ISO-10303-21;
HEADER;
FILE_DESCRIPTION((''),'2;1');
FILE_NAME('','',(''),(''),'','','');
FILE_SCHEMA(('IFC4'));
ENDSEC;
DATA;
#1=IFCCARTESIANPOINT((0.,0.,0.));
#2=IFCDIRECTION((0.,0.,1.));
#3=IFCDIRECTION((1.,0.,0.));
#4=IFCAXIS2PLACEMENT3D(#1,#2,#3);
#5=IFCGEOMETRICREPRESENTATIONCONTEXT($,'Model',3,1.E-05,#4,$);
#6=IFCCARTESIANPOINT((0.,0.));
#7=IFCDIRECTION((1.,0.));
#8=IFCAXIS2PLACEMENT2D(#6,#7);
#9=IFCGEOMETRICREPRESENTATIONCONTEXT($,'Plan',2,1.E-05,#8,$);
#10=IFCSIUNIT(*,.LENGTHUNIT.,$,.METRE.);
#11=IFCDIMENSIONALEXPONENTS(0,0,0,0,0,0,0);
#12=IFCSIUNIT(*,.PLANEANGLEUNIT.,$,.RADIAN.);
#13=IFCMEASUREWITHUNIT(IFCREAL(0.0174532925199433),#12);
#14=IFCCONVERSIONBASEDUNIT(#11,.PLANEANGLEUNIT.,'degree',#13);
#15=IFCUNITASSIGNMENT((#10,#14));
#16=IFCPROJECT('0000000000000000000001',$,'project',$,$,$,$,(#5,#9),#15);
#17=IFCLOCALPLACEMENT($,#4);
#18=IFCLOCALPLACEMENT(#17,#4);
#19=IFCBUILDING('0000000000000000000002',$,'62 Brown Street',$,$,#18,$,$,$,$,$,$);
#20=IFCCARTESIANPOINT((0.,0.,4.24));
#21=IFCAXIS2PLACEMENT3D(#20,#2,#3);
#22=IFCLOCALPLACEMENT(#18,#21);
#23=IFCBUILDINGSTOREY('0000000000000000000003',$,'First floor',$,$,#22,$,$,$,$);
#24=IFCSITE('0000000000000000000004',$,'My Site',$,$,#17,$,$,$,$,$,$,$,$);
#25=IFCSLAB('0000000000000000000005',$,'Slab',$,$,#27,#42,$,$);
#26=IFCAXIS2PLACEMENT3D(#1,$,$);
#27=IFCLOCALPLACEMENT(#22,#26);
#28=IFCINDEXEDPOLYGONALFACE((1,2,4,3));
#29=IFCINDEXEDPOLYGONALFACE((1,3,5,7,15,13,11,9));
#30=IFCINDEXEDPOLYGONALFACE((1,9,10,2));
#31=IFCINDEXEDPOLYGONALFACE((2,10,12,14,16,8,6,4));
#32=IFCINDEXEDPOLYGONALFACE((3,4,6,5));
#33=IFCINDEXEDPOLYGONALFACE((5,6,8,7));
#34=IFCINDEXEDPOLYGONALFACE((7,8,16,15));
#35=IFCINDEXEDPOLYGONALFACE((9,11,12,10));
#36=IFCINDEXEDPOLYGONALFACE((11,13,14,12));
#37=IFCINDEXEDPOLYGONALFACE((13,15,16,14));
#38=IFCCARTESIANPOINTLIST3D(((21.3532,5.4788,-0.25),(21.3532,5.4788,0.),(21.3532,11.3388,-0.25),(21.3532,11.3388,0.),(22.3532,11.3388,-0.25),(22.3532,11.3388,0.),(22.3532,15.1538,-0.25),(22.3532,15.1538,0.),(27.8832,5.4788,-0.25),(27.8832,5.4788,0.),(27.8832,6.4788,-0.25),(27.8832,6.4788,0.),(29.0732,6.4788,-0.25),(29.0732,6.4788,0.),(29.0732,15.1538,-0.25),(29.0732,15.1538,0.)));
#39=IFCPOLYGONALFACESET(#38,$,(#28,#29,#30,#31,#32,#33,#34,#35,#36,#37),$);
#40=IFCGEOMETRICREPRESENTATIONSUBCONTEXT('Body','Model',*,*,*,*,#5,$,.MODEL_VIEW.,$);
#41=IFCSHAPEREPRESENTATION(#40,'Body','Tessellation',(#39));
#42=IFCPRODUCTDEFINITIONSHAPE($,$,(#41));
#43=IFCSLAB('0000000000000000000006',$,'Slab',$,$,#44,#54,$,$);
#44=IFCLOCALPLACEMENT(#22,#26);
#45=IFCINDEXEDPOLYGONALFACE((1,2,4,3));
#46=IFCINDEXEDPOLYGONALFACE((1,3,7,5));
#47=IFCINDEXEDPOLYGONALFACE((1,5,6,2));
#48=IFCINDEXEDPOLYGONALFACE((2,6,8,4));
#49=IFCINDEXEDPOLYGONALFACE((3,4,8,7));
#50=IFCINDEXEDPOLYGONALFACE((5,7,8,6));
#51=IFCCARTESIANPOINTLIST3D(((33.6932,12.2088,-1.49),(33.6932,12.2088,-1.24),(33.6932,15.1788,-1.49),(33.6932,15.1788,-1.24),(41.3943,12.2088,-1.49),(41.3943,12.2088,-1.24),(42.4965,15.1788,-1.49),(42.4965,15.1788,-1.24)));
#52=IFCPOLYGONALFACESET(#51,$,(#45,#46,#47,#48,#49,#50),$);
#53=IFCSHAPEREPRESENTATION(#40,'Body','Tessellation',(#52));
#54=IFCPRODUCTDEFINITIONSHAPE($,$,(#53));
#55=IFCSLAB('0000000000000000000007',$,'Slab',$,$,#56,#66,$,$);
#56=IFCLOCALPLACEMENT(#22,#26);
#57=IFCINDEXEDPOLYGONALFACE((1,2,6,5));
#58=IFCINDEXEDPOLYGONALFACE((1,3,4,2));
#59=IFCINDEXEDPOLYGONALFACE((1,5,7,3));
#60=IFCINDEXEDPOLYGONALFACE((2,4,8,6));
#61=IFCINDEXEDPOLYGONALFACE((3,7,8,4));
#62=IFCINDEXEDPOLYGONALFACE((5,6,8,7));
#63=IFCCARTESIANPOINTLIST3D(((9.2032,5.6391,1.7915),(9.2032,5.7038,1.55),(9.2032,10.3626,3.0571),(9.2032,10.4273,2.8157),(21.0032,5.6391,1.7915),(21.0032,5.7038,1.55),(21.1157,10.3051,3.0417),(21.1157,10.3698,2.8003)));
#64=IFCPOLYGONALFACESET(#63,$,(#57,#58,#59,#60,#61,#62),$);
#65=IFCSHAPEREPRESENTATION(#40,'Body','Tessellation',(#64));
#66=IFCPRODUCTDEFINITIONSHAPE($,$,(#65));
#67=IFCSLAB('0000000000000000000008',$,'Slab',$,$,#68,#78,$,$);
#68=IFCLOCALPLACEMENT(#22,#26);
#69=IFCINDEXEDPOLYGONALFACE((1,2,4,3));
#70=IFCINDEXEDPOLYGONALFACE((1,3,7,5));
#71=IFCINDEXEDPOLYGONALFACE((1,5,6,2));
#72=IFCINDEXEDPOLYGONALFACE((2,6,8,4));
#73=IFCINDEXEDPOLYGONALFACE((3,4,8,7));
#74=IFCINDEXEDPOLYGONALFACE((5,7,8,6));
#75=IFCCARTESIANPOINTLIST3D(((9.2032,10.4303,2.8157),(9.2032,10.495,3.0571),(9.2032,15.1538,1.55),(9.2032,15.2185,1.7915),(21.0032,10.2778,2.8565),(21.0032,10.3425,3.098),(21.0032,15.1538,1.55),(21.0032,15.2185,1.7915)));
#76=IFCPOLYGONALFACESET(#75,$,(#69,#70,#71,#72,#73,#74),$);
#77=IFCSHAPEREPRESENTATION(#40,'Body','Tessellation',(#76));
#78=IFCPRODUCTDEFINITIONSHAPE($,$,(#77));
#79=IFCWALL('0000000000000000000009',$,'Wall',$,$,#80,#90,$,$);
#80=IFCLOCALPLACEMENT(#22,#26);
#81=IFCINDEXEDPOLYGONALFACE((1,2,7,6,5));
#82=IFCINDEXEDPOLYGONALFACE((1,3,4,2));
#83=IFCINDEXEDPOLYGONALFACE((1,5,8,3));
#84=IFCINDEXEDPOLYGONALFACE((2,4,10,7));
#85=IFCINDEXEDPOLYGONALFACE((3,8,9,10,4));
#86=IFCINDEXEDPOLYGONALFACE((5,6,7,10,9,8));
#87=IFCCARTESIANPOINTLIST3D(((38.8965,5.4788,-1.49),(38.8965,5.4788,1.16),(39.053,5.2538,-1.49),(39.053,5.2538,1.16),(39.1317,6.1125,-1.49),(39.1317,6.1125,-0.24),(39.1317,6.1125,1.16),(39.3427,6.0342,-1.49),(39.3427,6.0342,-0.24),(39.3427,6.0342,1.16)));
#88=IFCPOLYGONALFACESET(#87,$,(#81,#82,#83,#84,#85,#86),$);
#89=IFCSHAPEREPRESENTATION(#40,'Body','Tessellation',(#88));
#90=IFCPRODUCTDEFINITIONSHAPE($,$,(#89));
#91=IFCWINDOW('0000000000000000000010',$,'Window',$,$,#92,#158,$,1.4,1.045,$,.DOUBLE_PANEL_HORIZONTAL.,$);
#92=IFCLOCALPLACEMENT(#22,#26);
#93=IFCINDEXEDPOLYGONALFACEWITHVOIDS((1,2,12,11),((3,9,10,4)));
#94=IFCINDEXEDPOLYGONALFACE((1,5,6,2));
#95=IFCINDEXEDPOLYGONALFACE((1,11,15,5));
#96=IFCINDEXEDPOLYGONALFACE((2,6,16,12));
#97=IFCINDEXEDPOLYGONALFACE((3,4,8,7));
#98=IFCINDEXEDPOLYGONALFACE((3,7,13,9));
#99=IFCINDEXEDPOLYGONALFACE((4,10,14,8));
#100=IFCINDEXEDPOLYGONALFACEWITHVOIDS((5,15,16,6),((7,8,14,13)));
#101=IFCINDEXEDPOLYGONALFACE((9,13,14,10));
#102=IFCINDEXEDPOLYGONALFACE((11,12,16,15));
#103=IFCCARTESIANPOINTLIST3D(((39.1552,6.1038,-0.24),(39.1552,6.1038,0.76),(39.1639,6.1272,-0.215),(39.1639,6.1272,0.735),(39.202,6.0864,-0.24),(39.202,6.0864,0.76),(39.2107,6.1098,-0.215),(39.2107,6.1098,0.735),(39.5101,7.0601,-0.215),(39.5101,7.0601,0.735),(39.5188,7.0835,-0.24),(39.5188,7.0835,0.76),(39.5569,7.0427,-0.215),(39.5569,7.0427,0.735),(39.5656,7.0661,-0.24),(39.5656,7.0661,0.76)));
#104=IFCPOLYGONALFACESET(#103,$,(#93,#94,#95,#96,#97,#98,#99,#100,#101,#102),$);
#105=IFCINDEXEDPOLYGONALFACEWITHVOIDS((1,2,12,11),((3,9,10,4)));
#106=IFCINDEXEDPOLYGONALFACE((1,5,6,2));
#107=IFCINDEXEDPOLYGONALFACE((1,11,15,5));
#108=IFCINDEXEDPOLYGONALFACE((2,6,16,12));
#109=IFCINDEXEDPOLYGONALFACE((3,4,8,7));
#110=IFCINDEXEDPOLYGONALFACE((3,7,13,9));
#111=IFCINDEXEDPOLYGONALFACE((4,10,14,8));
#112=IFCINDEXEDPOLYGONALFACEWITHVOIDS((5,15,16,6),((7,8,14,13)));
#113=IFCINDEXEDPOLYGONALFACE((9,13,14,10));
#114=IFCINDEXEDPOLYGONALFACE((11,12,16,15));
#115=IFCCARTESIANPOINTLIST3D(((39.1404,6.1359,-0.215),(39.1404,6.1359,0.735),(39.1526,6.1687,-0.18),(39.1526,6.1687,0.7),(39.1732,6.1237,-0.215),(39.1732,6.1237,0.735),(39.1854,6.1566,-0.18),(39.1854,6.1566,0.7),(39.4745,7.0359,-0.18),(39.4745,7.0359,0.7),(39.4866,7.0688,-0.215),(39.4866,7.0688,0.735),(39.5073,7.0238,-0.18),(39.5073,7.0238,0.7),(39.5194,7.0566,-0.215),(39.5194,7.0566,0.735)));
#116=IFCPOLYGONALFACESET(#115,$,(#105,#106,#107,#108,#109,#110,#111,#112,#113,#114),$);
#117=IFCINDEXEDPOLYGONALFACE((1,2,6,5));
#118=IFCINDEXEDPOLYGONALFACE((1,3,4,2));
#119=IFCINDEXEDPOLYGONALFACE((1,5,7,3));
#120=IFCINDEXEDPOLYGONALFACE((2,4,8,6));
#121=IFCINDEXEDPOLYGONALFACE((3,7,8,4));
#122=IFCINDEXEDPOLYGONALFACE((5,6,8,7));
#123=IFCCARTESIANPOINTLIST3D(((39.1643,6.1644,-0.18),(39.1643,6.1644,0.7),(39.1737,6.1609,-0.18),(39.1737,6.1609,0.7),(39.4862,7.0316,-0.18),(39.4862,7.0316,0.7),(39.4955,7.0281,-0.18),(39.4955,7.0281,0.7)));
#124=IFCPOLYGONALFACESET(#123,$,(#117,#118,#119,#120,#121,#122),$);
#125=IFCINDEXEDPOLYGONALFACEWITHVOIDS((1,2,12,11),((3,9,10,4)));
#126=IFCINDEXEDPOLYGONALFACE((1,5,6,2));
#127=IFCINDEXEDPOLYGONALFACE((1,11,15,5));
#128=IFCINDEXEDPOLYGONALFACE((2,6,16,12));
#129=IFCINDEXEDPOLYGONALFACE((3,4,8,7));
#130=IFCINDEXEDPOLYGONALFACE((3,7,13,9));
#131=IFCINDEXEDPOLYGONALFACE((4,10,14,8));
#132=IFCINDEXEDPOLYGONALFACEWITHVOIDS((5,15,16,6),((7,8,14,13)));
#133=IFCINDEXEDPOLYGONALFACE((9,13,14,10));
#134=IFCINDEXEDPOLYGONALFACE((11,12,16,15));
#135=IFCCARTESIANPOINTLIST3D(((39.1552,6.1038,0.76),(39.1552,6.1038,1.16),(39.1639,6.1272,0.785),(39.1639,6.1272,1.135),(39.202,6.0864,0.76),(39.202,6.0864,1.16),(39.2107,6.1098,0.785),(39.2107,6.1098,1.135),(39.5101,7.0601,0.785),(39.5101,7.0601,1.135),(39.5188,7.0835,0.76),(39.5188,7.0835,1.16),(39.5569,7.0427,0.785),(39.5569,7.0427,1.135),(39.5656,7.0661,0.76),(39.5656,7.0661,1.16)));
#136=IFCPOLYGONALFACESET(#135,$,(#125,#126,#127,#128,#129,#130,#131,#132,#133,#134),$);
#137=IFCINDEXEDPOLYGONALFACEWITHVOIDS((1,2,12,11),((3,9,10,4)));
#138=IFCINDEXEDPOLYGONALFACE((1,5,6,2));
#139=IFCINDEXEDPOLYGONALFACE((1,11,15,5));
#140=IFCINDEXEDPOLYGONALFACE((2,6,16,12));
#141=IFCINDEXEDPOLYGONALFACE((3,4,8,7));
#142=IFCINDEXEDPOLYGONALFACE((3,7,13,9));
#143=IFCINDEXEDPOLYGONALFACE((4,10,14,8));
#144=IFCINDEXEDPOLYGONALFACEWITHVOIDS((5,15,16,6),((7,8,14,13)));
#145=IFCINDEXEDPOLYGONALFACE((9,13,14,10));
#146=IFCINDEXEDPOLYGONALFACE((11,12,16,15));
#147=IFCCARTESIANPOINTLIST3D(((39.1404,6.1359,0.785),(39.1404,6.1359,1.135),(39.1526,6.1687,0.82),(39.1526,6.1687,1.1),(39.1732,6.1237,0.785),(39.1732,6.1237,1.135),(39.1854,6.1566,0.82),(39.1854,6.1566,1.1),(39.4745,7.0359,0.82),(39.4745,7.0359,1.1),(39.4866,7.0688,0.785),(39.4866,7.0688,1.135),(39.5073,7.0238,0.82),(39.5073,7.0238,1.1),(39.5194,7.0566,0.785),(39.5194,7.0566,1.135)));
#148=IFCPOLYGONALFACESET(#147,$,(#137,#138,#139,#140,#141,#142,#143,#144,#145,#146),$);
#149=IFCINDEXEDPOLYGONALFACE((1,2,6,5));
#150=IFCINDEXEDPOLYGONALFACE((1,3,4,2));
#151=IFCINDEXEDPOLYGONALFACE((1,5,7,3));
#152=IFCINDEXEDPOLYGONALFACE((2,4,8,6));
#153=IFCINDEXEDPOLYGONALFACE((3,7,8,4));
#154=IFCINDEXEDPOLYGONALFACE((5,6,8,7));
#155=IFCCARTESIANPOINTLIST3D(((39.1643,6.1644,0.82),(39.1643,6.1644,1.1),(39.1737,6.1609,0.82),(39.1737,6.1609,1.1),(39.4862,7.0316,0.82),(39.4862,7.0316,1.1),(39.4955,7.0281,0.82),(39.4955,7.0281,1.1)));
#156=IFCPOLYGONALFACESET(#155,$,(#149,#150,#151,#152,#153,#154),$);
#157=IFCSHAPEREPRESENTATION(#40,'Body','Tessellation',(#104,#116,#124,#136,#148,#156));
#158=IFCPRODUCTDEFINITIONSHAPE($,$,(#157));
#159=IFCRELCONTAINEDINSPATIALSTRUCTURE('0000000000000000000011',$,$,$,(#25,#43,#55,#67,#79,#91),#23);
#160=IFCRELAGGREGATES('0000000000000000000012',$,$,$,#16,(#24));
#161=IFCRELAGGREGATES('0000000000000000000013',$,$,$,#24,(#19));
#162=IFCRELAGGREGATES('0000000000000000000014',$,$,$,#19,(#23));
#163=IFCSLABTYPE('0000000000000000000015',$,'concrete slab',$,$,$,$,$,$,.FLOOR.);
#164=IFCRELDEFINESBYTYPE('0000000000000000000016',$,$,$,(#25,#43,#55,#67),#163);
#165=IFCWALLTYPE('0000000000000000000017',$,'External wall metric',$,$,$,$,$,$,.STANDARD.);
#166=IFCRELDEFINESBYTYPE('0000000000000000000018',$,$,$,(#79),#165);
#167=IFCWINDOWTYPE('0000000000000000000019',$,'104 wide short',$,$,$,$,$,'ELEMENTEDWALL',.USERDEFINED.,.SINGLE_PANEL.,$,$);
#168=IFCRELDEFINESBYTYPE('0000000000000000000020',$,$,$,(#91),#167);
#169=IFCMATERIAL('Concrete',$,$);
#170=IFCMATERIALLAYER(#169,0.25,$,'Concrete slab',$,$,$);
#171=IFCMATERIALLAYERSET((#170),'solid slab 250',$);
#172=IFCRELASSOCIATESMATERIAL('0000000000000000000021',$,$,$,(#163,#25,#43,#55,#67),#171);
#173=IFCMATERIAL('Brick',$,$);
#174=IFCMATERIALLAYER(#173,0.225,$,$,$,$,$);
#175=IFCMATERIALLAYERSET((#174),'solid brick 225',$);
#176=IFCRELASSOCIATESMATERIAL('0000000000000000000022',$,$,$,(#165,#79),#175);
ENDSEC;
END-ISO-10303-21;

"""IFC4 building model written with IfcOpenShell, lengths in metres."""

from ifc_helpers import new_model, entity, si_unit, converted_unit, frame, origin_with_axes, origin_2d_with_axis, place, context, subcontext, project, spatial, line, indexed_curve, outline, extrude, clip, halfspace, shape, source, transform, mapped, material, layer, layer_set, layer_usage, type_object, type_shapes, element, fill, save


model = new_model("IFC4")

# Units and contexts
model_context = context("Model", 3, precision=1e-05, world=origin_with_axes())
plan_context = context("Plan", 2, precision=1e-05, world=origin_2d_with_axis())
body_context_1 = subcontext(model_context, "Body", "Model", "MODEL_VIEW")
body_context_2 = subcontext(plan_context, "Body", "Plan", "PLAN_VIEW")
ifc_project = project(units=[si_unit("LENGTHUNIT", "METRE"), converted_unit("PLANEANGLEUNIT", "degree", entity("IfcReal", 0.0174532925199433), si_unit("PLANEANGLEUNIT", "RADIAN"), dimensions=[0, 0, 0, 0, 0, 0, 0])], contexts=[model_context, plan_context])

# Site, building, storey
site_placement = place(None, origin_with_axes())
site = spatial("IfcSite", under=ifc_project, at=site_placement, Name="My Site")
building_placement = place(site_placement, origin_with_axes())
building = spatial("IfcBuilding", under=site, at=building_placement, Name="62 Brown Street")
storey_placement = place(building_placement, frame((0.0, 0.0, 4.24), z_axis=(0.0, 0.0, 1.0), x_axis=(1.0, 0.0, 0.0)))
storey = spatial("IfcBuildingStorey", under=building, at=storey_placement, Name="First floor")

# Slabs
ifc_material_1 = material(Name="Concrete")
ifc_layer_1 = layer(ifc_material_1, 0.25, Name="Concrete slab")
ifc_layer_set_1 = layer_set([ifc_layer_1], Name="solid slab 250")
ifc_layer_usage_1 = layer_usage(ifc_layer_set_1, "AXIS3", "POSITIVE", 0.0)
slab_type = type_object("IfcSlabType", Name="concrete slab", PredefinedType="FLOOR", material=ifc_layer_set_1)
slab_1_placement = place(storey_placement, frame((21.3532, 5.4788, -0.25), z_axis=(0.0, 0.0, 1.0), x_axis=(1.0, 0.0, 0.0)))
element("IfcSlab", 1, at=slab_1_placement, inside=storey, type_object=slab_type, material=ifc_layer_usage_1, Name="Slab", context=body_context_1, shape_type="SweptSolid", body=[
    extrude(outline(indexed_curve([(0.0, 0.0), (0.0, 5.86), (1.0, 5.86), (1.0, 9.675), (7.72, 9.675), (7.72, 1.0), (6.53, 1.0), (6.53, 0.0)], segments=[line(2, 1), line(1, 8), line(8, 7), line(7, 6), line(6, 5), line(5, 4), line(4, 3), line(3, 2)], self_intersect=False)), None, (0.0, 0.0, 1.0), 0.25),
])
ifc_layer_usage_2 = layer_usage(ifc_layer_set_1, "AXIS3", "POSITIVE", 0.0)
slab_2_placement = place(storey_placement, frame((33.6932, 12.2088, -1.49), z_axis=(0.0, 0.0, 1.0), x_axis=(1.0, 0.0, 0.0)))
element("IfcSlab", 2, at=slab_2_placement, inside=storey, type_object=slab_type, material=ifc_layer_usage_2, Name="Slab", context=body_context_1, shape_type="SweptSolid", body=[
    extrude(outline(indexed_curve([(8.8033, 2.97), (7.7011, 0.0), (0.0, 0.0), (0.0, 2.97)], segments=[line(4, 1), line(1, 2), line(2, 3), line(3, 4)], self_intersect=False)), None, (0.0, 0.0, 1.0), 0.25),
])
ifc_layer_usage_3 = layer_usage(ifc_layer_set_1, "AXIS3", "POSITIVE", 0.0)
slab_3_placement = place(storey_placement, frame((9.2032, 5.7038, 1.55), z_axis=(0.0, -0.258819, 0.965926), x_axis=(1.0, 0.0, 0.0)))
element("IfcSlab", 3, at=slab_3_placement, inside=storey, type_object=slab_type, material=ifc_layer_usage_3, Name="Slab", context=body_context_1, shape_type="SweptSolid", body=[
    extrude(outline(indexed_curve([(0.0, 0.0), (11.8, 0.0), (11.9125, 4.8306), (0.0, 4.8901)], segments=[line(4, 1), line(1, 2), line(2, 3), line(3, 4)], self_intersect=False)), None, (0.0, 0.0, 1.0), 0.25),
])
ifc_layer_usage_4 = layer_usage(ifc_layer_set_1, "AXIS3", "POSITIVE", 0.0)
slab_4_placement = place(storey_placement, frame((21.0032, 15.1538, 1.55), z_axis=(0.0, 0.258819, 0.965926), x_axis=(-1.0, 0.0, 0.0)))
element("IfcSlab", 4, at=slab_4_placement, inside=storey, type_object=slab_type, material=ifc_layer_usage_4, Name="Slab", context=body_context_1, shape_type="SweptSolid", body=[
    extrude(outline(indexed_curve([(0.0, 0.0), (11.8, 0.0), (11.8, 4.8901), (0.0, 5.048)], segments=[line(4, 1), line(1, 2), line(2, 3), line(3, 4)], self_intersect=False)), None, (0.0, 0.0, 1.0), 0.25),
])

# Shared definitions
ifc_material_2 = material(Name="Brick")
ifc_layer_2 = layer(ifc_material_2, 0.225)
ifc_layer_set_2 = layer_set([ifc_layer_2], Name="solid brick 225")
wall_type_1 = type_object("IfcWallType", Name="External wall metric", PredefinedType="STANDARD", material=ifc_layer_set_2)

# Wall, opening, window
ifc_layer_usage_5 = layer_usage(ifc_layer_set_2, "AXIS2", "POSITIVE", 0.0)
wall_1_placement = place(storey_placement, frame((39.024, 5.1755, -1.49), z_axis=(0.0, 0.0, 1.0), x_axis=(0.347944, 0.937515, 0.0)))
wall_1 = element("IfcWall", 5, at=wall_1_placement, inside=storey, type_object=wall_type_1, material=ifc_layer_usage_5, Name="Wall", context=body_context_1, shape_type="Clipping", body=[
    clip(extrude(outline(indexed_curve([(0.0, 0.0), (0.0, 0.225), (0.9159, 0.225), (0.9159, 0.0), (0.0, 0.0)], self_intersect=False)), origin_with_axes(), (0.0, 0.0, 1.0), 2.65), halfspace(frame((0.0835, 0.0, -2.75), z_axis=(-0.596249, 0.414702, 0.0), x_axis=(0.156491, 0.225, 0.0)), False)),
])
shared_shape_1 = source(origin_with_axes(), body_context_1, "Body", "SweptSolid", [
    extrude(outline(indexed_curve([(0.0, 0.0), (1.045, 0.0), (1.045, 1.4), (0.0, 1.4)], segments=[line(1, 2, 3, 4, 1)])), frame((0.0, -0.1, 0.0), z_axis=(0.0, -1.0, 0.0), x_axis=(1.0, 0.0, 0.0)), (0.0, 0.0, -1.0), 0.425),
])
opening_placement = place(wall_1_placement, frame((0.9159, 0.0, 1.25), z_axis=(0.0, 0.0, 1.0), x_axis=(1.0, 0.0, 0.0)))
opening = element("IfcOpeningElement", 6, at=opening_placement, cuts=wall_1, PredefinedType="OPENING", context=body_context_1, shape_type="MappedRepresentation", body=[
    mapped(shared_shape_1, transform((0.0, 0.0, 0.0), x_axis=(1.0, 0.0, 0.0), y_axis=(0.0, 1.0, 0.0), z_axis=(0.0, 0.0, 1.0), scale=1.0)),
])
window_type = type_object("IfcWindowType", Name="104 wide short", ElementType="ELEMENTEDWALL", PartitioningType="SINGLE_PANEL", PredefinedType="USERDEFINED")
shared_shape_2 = source(origin_with_axes(), body_context_1, "Body", "SweptSolid", [
    extrude(outline(indexed_curve([(0.0, 0.0), (1.045, 0.0), (1.045, 1.0), (0.0, 1.0)], segments=[line(1, 2, 3, 4, 1)]), holes=[indexed_curve([(0.025, 0.025), (1.02, 0.025), (1.02, 0.975), (0.025, 0.975)], segments=[line(1, 2, 3, 4, 1)])]), frame((0.0, 0.15, 0.0), z_axis=(0.0, -1.0, 0.0), x_axis=(1.0, 0.0, 0.0)), (0.0, 0.0, -1.0), 0.05),
    extrude(outline(indexed_curve([(0.0, 0.0), (0.995, 0.0), (0.995, 0.95), (0.0, 0.95)], segments=[line(1, 2, 3, 4, 1)]), holes=[indexed_curve([(0.035, 0.035), (0.96, 0.035), (0.96, 0.915), (0.035, 0.915)], segments=[line(1, 2, 3, 4, 1)])]), frame((0.025, 0.19, 0.025), z_axis=(0.0, -1.0, 0.0), x_axis=(1.0, 0.0, 0.0)), (0.0, 0.0, -1.0), 0.035),
    extrude(outline(indexed_curve([(0.035, 0.035), (0.96, 0.035), (0.96, 0.915), (0.035, 0.915)], segments=[line(1, 2, 3, 4, 1)])), frame((0.025, 0.2025, 0.025), z_axis=(0.0, -1.0, 0.0), x_axis=(1.0, 0.0, 0.0)), (0.0, 0.0, -1.0), 0.01),
    extrude(outline(indexed_curve([(0.0, 0.0), (1.045, 0.0), (1.045, 0.4), (0.0, 0.4)], segments=[line(1, 2, 3, 4, 1)]), holes=[indexed_curve([(0.025, 0.025), (1.02, 0.025), (1.02, 0.375), (0.025, 0.375)], segments=[line(1, 2, 3, 4, 1)])]), frame((0.0, 0.15, 1.0), z_axis=(0.0, -1.0, 0.0), x_axis=(1.0, 0.0, 0.0)), (0.0, 0.0, -1.0), 0.05),
    extrude(outline(indexed_curve([(0.0, 0.0), (0.995, 0.0), (0.995, 0.35), (0.0, 0.35)], segments=[line(1, 2, 3, 4, 1)]), holes=[indexed_curve([(0.035, 0.035), (0.96, 0.035), (0.96, 0.315), (0.035, 0.315)], segments=[line(1, 2, 3, 4, 1)])]), frame((0.025, 0.19, 1.025), z_axis=(0.0, -1.0, 0.0), x_axis=(1.0, 0.0, 0.0)), (0.0, 0.0, -1.0), 0.035),
    extrude(outline(indexed_curve([(0.035, 0.035), (0.96, 0.035), (0.96, 0.315), (0.035, 0.315)], segments=[line(1, 2, 3, 4, 1)])), frame((0.025, 0.2025, 1.025), z_axis=(0.0, -1.0, 0.0), x_axis=(1.0, 0.0, 0.0)), (0.0, 0.0, -1.0), 0.01),
])
shared_shape_3 = source(origin_with_axes(), body_context_2, "Body", "Curve2D", [
    entity("IfcIndexedPolyCurve", entity("IfcCartesianPointList2D", [[0.025, 0.15], [1.02, 0.15]])),
    entity("IfcIndexedPolyCurve", entity("IfcCartesianPointList2D", [[0.0, 0.2], [0.025, 0.2], [0.025, 0.15], [0.0, 0.15]]), [entity("IfcLineIndex", [1, 2, 3, 4, 1])]),
    entity("IfcIndexedPolyCurve", entity("IfcCartesianPointList2D", [[1.045, 0.2], [1.02, 0.2], [1.02, 0.15], [1.045, 0.15]]), [entity("IfcLineIndex", [1, 2, 3, 4, 1])]),
    entity("IfcIndexedPolyCurve", entity("IfcCartesianPointList2D", [[0.025, 0.19], [0.06, 0.19], [0.06, 0.225], [0.025, 0.225]]), [entity("IfcLineIndex", [1, 2, 3, 4, 1])]),
    entity("IfcIndexedPolyCurve", entity("IfcCartesianPointList2D", [[1.02, 0.19], [0.985, 0.19], [0.985, 0.225], [1.02, 0.225]]), [entity("IfcLineIndex", [1, 2, 3, 4, 1])]),
    entity("IfcIndexedPolyCurve", entity("IfcCartesianPointList2D", [[0.06, 0.19], [0.985, 0.19]])),
    entity("IfcIndexedPolyCurve", entity("IfcCartesianPointList2D", [[0.06, 0.225], [0.985, 0.225]])),
    entity("IfcIndexedPolyCurve", entity("IfcCartesianPointList2D", [[0.06, 0.2075], [0.985, 0.2075]])),
])
type_shapes(window_type, [shared_shape_2, shared_shape_3])
window_1_placement = place(opening_placement, frame((0.0, 0.0, 0.0), z_axis=(0.0, 0.0, 1.0), x_axis=(1.0, 0.0, 0.0)))
window_1 = element("IfcWindow", 7, at=window_1_placement, inside=storey, type_object=window_type, Name="Window", OverallHeight=1.4, OverallWidth=1.045, PartitioningType="DOUBLE_PANEL_HORIZONTAL", shapes=[
    shape(body_context_1, "Body", "MappedRepresentation", [mapped(shared_shape_2, transform((0.0, 0.0, 0.0), x_axis=(1.0, 0.0, 0.0), y_axis=(0.0, 1.0, 0.0), z_axis=(0.0, 0.0, 1.0), scale=1.0))]),
    shape(body_context_2, "Body", "MappedRepresentation", [mapped(shared_shape_3, transform((0.0, 0.0, 0.0), x_axis=(1.0, 0.0, 0.0), y_axis=(0.0, 1.0, 0.0), z_axis=(0.0, 0.0, 1.0), scale=1.0))]),
])
fill(opening, window_1)

save(model, "model.ifc")
